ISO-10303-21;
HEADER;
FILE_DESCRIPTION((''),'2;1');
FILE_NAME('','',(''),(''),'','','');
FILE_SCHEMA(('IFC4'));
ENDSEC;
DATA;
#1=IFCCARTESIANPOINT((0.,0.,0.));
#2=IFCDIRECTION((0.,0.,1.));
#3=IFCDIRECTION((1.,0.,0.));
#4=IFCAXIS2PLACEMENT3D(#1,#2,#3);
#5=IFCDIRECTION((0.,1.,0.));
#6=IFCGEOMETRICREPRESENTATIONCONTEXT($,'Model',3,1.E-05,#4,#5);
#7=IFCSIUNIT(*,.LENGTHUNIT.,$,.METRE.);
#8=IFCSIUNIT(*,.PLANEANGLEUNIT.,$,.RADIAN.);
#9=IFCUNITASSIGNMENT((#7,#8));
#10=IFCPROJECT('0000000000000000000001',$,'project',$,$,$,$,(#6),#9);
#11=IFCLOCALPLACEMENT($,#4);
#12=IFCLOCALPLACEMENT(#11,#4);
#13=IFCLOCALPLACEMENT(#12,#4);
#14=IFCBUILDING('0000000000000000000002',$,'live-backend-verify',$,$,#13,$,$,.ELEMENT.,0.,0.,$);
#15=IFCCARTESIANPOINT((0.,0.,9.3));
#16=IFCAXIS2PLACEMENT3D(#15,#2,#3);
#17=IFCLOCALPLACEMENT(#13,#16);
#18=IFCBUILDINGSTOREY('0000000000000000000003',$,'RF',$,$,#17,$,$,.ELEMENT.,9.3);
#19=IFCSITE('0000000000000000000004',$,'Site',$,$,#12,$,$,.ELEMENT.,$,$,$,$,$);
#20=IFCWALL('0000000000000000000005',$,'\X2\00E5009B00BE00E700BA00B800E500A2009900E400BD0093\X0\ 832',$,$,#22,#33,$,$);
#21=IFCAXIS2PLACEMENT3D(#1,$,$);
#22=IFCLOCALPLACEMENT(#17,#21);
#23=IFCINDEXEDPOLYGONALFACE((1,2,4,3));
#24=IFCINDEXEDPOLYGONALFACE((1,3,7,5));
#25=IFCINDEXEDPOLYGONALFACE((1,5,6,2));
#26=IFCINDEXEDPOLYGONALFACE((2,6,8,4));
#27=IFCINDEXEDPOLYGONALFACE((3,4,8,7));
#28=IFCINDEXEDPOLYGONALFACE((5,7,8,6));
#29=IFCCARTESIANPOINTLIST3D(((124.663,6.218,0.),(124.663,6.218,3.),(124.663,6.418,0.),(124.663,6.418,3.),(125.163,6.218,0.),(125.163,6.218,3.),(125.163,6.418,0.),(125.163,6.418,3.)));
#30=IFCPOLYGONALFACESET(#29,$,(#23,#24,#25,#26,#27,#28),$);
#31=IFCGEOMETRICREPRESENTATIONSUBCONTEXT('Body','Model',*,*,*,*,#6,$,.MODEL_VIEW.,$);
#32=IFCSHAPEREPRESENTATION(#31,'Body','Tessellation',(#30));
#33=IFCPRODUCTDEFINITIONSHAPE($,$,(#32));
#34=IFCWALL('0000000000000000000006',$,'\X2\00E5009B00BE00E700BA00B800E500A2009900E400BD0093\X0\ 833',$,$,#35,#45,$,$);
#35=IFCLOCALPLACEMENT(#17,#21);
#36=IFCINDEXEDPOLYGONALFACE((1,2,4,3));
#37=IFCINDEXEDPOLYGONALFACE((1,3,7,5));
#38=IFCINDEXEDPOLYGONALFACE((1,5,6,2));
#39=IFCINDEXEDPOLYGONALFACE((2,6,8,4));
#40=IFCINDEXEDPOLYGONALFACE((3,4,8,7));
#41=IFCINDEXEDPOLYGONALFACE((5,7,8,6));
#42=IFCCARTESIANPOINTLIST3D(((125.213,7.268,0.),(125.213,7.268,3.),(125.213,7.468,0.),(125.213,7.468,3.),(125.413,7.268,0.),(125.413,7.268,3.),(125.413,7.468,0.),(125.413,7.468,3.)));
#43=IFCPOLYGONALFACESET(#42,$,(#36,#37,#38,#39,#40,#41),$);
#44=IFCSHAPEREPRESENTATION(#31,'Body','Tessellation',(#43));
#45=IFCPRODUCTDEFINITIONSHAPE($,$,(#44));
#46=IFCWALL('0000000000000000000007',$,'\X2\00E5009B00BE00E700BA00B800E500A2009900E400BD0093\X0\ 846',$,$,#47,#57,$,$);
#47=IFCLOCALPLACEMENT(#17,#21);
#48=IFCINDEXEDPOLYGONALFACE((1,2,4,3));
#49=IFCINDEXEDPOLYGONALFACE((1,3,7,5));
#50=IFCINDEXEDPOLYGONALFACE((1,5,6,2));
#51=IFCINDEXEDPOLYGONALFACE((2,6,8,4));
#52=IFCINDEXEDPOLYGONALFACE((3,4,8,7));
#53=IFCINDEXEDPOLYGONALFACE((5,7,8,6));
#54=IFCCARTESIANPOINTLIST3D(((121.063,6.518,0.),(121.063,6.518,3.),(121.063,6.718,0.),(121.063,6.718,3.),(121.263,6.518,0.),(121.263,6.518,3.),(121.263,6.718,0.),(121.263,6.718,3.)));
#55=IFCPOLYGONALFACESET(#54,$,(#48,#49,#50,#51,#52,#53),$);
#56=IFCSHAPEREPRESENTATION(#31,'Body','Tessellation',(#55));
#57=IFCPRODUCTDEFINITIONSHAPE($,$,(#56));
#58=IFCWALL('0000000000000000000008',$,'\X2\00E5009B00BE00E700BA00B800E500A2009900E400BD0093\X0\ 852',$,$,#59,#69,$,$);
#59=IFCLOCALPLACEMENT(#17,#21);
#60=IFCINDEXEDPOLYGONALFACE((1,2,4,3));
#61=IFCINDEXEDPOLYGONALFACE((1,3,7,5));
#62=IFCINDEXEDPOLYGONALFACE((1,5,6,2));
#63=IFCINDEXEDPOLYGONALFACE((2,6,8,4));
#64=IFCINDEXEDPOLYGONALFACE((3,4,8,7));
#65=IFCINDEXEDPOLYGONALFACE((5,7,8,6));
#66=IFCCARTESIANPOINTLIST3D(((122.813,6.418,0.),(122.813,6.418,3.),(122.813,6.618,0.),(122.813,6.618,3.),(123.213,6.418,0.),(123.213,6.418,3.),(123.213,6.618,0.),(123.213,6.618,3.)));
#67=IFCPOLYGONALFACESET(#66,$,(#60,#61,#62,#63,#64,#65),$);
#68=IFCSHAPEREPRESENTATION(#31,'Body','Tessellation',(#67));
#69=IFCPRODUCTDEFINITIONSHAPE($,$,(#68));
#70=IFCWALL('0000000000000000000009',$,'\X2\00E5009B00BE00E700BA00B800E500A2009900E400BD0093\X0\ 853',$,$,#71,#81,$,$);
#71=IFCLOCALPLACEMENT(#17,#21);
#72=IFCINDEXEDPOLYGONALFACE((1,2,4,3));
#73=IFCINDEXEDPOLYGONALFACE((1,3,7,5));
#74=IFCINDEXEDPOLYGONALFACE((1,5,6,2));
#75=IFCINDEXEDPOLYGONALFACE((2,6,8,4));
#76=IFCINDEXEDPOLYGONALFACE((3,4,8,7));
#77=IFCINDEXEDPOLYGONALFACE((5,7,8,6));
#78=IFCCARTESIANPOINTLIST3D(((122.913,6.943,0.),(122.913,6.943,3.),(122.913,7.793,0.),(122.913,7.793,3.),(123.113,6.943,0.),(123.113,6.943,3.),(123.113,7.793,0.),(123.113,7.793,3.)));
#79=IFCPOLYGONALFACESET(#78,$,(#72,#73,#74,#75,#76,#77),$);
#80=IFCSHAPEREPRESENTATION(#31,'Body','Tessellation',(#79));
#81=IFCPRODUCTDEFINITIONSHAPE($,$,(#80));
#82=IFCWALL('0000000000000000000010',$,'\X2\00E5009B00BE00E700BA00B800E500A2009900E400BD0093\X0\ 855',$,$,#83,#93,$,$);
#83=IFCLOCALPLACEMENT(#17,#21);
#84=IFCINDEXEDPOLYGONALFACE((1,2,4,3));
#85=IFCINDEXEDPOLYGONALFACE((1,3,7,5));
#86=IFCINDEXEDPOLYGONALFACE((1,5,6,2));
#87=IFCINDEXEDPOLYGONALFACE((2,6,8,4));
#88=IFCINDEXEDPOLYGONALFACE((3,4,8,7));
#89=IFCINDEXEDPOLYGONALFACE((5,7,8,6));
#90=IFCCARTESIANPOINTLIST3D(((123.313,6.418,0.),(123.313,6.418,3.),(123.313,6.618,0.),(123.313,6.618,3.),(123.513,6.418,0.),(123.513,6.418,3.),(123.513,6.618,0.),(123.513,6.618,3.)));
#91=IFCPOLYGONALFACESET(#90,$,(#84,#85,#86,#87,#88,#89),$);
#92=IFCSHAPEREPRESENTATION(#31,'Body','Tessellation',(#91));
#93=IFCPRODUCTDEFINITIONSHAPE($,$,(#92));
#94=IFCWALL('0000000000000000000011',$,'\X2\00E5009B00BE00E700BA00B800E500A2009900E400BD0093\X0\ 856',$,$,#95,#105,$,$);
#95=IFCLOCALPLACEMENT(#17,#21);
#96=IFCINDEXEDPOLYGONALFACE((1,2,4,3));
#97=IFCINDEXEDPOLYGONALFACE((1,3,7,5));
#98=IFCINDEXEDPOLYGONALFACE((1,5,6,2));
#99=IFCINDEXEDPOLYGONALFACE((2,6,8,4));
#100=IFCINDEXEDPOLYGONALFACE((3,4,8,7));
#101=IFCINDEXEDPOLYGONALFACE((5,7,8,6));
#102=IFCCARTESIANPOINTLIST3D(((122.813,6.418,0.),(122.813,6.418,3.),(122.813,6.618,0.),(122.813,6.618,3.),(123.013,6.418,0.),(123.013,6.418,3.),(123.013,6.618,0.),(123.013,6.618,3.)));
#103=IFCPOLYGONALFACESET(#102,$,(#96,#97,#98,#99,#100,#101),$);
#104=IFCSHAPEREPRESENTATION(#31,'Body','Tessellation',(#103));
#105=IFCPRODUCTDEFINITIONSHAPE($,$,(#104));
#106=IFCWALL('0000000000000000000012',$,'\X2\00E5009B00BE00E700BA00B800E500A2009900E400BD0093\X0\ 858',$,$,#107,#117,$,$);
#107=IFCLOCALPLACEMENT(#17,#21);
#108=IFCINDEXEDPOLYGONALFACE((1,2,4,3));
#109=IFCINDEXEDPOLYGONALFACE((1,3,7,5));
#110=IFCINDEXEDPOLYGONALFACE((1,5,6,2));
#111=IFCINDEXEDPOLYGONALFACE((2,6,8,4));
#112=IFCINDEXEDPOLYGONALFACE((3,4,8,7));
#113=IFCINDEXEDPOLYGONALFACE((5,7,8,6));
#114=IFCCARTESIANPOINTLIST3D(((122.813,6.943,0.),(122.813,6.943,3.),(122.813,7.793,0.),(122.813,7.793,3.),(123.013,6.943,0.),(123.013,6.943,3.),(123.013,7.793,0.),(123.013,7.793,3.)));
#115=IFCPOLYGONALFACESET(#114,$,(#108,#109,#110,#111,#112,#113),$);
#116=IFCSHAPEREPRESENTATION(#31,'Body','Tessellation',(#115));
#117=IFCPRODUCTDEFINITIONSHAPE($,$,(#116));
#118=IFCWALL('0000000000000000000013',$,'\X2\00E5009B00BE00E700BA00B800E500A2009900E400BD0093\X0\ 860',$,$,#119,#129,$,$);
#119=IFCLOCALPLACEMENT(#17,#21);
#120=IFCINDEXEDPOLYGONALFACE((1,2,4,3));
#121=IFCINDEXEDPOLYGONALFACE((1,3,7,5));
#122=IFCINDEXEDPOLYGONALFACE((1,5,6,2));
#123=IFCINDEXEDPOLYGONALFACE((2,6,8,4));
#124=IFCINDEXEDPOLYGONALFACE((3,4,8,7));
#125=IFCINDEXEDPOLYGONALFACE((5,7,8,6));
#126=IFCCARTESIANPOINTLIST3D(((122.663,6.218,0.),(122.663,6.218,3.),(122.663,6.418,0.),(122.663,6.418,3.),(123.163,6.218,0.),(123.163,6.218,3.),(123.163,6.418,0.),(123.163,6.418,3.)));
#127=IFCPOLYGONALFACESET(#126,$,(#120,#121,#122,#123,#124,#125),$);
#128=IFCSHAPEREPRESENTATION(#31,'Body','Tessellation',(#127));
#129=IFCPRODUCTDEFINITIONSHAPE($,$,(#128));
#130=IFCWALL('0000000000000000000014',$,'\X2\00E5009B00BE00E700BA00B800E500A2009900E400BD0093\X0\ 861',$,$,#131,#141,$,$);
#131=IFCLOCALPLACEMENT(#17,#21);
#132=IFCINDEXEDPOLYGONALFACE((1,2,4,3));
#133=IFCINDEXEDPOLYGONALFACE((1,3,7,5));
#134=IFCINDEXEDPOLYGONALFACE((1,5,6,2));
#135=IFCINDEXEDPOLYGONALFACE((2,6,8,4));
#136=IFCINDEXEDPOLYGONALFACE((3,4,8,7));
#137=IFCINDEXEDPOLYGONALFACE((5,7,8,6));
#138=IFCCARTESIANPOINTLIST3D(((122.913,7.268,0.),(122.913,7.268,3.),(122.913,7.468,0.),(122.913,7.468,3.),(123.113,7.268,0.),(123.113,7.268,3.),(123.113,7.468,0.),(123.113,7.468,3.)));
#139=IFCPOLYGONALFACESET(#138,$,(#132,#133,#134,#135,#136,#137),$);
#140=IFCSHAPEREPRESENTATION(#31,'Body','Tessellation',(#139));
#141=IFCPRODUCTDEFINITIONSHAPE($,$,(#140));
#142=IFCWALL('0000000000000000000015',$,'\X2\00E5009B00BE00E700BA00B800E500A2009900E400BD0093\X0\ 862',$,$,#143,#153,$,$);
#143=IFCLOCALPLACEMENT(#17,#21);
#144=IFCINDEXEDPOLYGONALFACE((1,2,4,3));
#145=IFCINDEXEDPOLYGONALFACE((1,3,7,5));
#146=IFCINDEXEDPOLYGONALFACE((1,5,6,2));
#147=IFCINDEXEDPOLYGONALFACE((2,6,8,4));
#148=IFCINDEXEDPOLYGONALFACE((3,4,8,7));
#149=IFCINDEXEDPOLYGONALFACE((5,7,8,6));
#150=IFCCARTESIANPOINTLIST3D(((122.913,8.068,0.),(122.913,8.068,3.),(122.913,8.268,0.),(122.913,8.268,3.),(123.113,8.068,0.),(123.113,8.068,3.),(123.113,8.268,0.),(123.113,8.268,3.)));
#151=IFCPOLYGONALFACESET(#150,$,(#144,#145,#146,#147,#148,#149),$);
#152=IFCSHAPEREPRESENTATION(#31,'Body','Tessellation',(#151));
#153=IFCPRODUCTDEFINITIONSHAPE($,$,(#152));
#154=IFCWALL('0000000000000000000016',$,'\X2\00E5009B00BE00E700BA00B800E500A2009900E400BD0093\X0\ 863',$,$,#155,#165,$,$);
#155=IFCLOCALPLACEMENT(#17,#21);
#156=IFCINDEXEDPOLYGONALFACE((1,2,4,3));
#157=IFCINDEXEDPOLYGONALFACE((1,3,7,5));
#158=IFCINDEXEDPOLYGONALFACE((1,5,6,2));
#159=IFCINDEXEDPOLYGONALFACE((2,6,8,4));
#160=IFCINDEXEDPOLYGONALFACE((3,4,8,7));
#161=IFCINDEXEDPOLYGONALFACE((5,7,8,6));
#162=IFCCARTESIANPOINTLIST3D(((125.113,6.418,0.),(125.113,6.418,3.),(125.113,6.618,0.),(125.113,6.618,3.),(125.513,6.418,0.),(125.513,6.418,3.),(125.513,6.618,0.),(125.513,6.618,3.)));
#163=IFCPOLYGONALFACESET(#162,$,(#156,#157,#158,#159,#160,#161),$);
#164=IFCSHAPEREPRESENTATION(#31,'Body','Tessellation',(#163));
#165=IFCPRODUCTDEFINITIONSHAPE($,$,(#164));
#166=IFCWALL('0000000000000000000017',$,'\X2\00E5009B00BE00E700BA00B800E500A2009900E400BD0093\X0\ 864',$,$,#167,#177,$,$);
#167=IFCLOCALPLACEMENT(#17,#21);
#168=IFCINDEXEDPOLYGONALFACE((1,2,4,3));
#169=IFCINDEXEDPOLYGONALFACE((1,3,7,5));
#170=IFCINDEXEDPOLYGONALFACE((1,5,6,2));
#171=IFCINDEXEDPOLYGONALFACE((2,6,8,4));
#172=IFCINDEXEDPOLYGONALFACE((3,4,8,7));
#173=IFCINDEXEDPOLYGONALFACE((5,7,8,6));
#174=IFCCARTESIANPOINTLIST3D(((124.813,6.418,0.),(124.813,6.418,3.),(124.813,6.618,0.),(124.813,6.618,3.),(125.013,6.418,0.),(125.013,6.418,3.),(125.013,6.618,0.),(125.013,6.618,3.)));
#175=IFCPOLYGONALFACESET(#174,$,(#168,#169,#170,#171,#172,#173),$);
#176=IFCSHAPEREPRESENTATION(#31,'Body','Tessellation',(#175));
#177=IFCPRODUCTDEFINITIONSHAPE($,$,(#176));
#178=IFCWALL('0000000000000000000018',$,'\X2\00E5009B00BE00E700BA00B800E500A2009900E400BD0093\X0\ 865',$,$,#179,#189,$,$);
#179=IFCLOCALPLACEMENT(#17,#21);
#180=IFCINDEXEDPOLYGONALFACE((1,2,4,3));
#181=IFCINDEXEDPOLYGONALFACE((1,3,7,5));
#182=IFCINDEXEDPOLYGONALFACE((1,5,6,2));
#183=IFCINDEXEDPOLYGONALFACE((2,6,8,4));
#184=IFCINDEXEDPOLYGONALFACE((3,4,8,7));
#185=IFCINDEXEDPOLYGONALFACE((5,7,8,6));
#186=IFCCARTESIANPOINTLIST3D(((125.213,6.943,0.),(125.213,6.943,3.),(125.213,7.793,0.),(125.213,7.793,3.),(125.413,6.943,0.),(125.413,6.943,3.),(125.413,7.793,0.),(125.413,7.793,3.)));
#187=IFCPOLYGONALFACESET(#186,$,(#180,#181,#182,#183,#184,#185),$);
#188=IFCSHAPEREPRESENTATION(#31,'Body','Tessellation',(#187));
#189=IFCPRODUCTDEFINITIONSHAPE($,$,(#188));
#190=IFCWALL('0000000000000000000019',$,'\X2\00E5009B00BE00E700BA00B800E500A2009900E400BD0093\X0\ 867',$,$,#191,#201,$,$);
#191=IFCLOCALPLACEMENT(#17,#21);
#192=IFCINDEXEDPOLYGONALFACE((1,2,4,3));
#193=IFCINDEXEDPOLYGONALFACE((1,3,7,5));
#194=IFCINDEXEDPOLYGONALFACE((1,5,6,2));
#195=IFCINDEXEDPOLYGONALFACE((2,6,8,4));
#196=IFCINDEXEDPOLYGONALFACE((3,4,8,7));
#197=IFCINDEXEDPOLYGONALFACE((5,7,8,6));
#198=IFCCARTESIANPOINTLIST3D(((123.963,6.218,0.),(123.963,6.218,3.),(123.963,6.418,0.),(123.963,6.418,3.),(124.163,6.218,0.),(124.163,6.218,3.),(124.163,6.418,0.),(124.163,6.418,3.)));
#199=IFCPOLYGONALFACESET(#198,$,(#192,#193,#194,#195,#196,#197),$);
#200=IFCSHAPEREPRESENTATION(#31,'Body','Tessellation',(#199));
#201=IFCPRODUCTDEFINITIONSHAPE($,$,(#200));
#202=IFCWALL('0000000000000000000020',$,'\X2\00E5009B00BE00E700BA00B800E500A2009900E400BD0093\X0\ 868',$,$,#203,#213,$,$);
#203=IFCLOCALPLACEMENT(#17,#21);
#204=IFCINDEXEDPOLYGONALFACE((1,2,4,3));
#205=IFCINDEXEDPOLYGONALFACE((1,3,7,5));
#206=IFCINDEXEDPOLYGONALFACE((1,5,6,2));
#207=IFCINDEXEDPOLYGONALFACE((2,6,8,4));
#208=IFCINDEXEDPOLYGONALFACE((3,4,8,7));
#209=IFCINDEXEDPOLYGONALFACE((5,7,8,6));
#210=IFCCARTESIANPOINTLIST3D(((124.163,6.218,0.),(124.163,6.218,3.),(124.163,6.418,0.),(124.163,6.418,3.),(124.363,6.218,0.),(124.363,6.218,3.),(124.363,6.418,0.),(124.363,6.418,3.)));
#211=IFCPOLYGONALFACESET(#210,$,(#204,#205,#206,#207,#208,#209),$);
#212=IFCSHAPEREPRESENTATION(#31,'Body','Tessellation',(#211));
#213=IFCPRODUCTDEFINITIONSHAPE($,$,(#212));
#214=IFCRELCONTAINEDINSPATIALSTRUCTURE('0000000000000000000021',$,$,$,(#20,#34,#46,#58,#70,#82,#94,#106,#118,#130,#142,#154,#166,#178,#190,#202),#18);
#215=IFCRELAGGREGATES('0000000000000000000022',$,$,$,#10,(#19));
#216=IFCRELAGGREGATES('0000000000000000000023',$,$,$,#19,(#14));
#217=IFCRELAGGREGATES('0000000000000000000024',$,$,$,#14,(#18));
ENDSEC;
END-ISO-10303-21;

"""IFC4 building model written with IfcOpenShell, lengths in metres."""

from ifc_helpers import new_model, si_unit, direction, frame, frame_2d, origin_with_axes, place, context, subcontext, project, spatial, rectangle, extrude, element, save


model = new_model("IFC4")

# Units and contexts
model_context = context("Model", 3, precision=1e-05, world=origin_with_axes(), true_north=direction((0.0, 1.0, 0.0)))
body_context = subcontext(model_context, "Body", "Model", "MODEL_VIEW")
ifc_project = project(units=[si_unit("LENGTHUNIT", "METRE"), si_unit("PLANEANGLEUNIT", "RADIAN")], contexts=[model_context])

# Site, building, storey
placement = place(None, origin_with_axes())
site_placement = place(placement, origin_with_axes())
site = spatial("IfcSite", under=ifc_project, at=site_placement, Name="Site", CompositionType="ELEMENT")
building_placement = place(site_placement, origin_with_axes())
building = spatial("IfcBuilding", under=site, at=building_placement, Name="live-backend-verify", CompositionType="ELEMENT", ElevationOfRefHeight=0.0, ElevationOfTerrain=0.0)
storey_placement = place(building_placement, frame((0.0, 0.0, 9.3), z_axis=(0.0, 0.0, 1.0), x_axis=(1.0, 0.0, 0.0)))
storey = spatial("IfcBuildingStorey", under=building, at=storey_placement, Name="RF", CompositionType="ELEMENT", Elevation=9.3)

# Walls
wall_1_placement = place(storey_placement, frame((124.913, 6.318, 0.0), z_axis=(0.0, 0.0, 1.0), x_axis=(1.0, 0.0, 0.0)))
element("IfcWall", 1, at=wall_1_placement, inside=storey, Name="å\u009b¾çº¸å¢\u0099ä½\u0093 832", context=body_context, shape_type="SweptSolid", body=[
    extrude(rectangle(XDim=0.5, YDim=0.2, at=frame_2d((0.0, 0.0), x_axis=(1.0, 0.0, 0.0))), frame((0.0, 0.0, 0.0), z_axis=(0.0, 0.0, 1.0)), (0.0, 0.0, 1.0), 3.0),
])
for number, where, z_axis, x_axis, name in (
    (2, (125.313, 7.368, 0.0), (0.0, 0.0, 1.0), (1.0, 0.0, 0.0), "å\u009b¾çº¸å¢\u0099ä½\u0093 833"),
    (3, (121.163, 6.618, 0.0), (0.0, 0.0, 1.0), (0.0, -1.0, 0.0), "å\u009b¾çº¸å¢\u0099ä½\u0093 846"),
):
    element("IfcWall", number, at=place(storey_placement, frame(where, z_axis=z_axis, x_axis=x_axis)), inside=storey, Name=name, context=body_context, shape_type="SweptSolid", body=[
        extrude(rectangle(XDim=0.2, YDim=0.2, at=frame_2d((0.0, 0.0), x_axis=(1.0, 0.0, 0.0))), frame((0.0, 0.0, 0.0), z_axis=(0.0, 0.0, 1.0)), (0.0, 0.0, 1.0), 3.0),
    ])
wall_2_placement = place(storey_placement, frame((123.013, 6.518, 0.0), z_axis=(0.0, 0.0, 1.0), x_axis=(1.0, 0.0, 0.0)))
element("IfcWall", 4, at=wall_2_placement, inside=storey, Name="å\u009b¾çº¸å¢\u0099ä½\u0093 852", context=body_context, shape_type="SweptSolid", body=[
    extrude(rectangle(XDim=0.4, YDim=0.2, at=frame_2d((0.0, 0.0), x_axis=(1.0, 0.0, 0.0))), frame((0.0, 0.0, 0.0), z_axis=(0.0, 0.0, 1.0)), (0.0, 0.0, 1.0), 3.0),
])
wall_3_placement = place(storey_placement, frame((123.013, 7.368, 0.0), z_axis=(0.0, 0.0, 1.0), x_axis=(0.0, -1.0, 0.0)))
element("IfcWall", 5, at=wall_3_placement, inside=storey, Name="å\u009b¾çº¸å¢\u0099ä½\u0093 853", context=body_context, shape_type="SweptSolid", body=[
    extrude(rectangle(XDim=0.85, YDim=0.2, at=frame_2d((0.0, 0.0), x_axis=(1.0, 0.0, 0.0))), frame((0.0, 0.0, 0.0), z_axis=(0.0, 0.0, 1.0)), (0.0, 0.0, 1.0), 3.0),
])
for number, where, z_axis, x_axis, name in (
    (6, (123.413, 6.518, 0.0), (0.0, 0.0, 1.0), (0.0, -1.0, 0.0), "å\u009b¾çº¸å¢\u0099ä½\u0093 855"),
    (7, (122.913, 6.518, 0.0), (0.0, 0.0, 1.0), (0.0, -1.0, 0.0), "å\u009b¾çº¸å¢\u0099ä½\u0093 856"),
):
    element("IfcWall", number, at=place(storey_placement, frame(where, z_axis=z_axis, x_axis=x_axis)), inside=storey, Name=name, context=body_context, shape_type="SweptSolid", body=[
        extrude(rectangle(XDim=0.2, YDim=0.2, at=frame_2d((0.0, 0.0), x_axis=(1.0, 0.0, 0.0))), frame((0.0, 0.0, 0.0), z_axis=(0.0, 0.0, 1.0)), (0.0, 0.0, 1.0), 3.0),
    ])
wall_4_placement = place(storey_placement, frame((122.913, 7.368, 0.0), z_axis=(0.0, 0.0, 1.0), x_axis=(0.0, -1.0, 0.0)))
element("IfcWall", 8, at=wall_4_placement, inside=storey, Name="å\u009b¾çº¸å¢\u0099ä½\u0093 858", context=body_context, shape_type="SweptSolid", body=[
    extrude(rectangle(XDim=0.85, YDim=0.2, at=frame_2d((0.0, 0.0), x_axis=(1.0, 0.0, 0.0))), frame((0.0, 0.0, 0.0), z_axis=(0.0, 0.0, 1.0)), (0.0, 0.0, 1.0), 3.0),
])
wall_5_placement = place(storey_placement, frame((122.913, 6.318, 0.0), z_axis=(0.0, 0.0, 1.0), x_axis=(1.0, 0.0, 0.0)))
element("IfcWall", 9, at=wall_5_placement, inside=storey, Name="å\u009b¾çº¸å¢\u0099ä½\u0093 860", context=body_context, shape_type="SweptSolid", body=[
    extrude(rectangle(XDim=0.5, YDim=0.2, at=frame_2d((0.0, 0.0), x_axis=(1.0, 0.0, 0.0))), frame((0.0, 0.0, 0.0), z_axis=(0.0, 0.0, 1.0)), (0.0, 0.0, 1.0), 3.0),
])
for number, where, z_axis, x_axis, name in (
    (10, (123.013, 7.368, 0.0), (0.0, 0.0, 1.0), (-1.0, 0.0, 0.0), "å\u009b¾çº¸å¢\u0099ä½\u0093 861"),
    (11, (123.013, 8.168, 0.0), (0.0, 0.0, 1.0), (-1.0, 0.0, 0.0), "å\u009b¾çº¸å¢\u0099ä½\u0093 862"),
):
    element("IfcWall", number, at=place(storey_placement, frame(where, z_axis=z_axis, x_axis=x_axis)), inside=storey, Name=name, context=body_context, shape_type="SweptSolid", body=[
        extrude(rectangle(XDim=0.2, YDim=0.2, at=frame_2d((0.0, 0.0), x_axis=(1.0, 0.0, 0.0))), frame((0.0, 0.0, 0.0), z_axis=(0.0, 0.0, 1.0)), (0.0, 0.0, 1.0), 3.0),
    ])
wall_6_placement = place(storey_placement, frame((125.313, 6.518, 0.0), z_axis=(0.0, 0.0, 1.0), x_axis=(-1.0, 0.0, 0.0)))
element("IfcWall", 12, at=wall_6_placement, inside=storey, Name="å\u009b¾çº¸å¢\u0099ä½\u0093 863", context=body_context, shape_type="SweptSolid", body=[
    extrude(rectangle(XDim=0.4, YDim=0.2, at=frame_2d((0.0, 0.0), x_axis=(1.0, 0.0, 0.0))), frame((0.0, 0.0, 0.0), z_axis=(0.0, 0.0, 1.0)), (0.0, 0.0, 1.0), 3.0),
])
wall_7_placement = place(storey_placement, frame((124.913, 6.518, 0.0), z_axis=(0.0, 0.0, 1.0), x_axis=(0.0, -1.0, 0.0)))
element("IfcWall", 13, at=wall_7_placement, inside=storey, Name="å\u009b¾çº¸å¢\u0099ä½\u0093 864", context=body_context, shape_type="SweptSolid", body=[
    extrude(rectangle(XDim=0.2, YDim=0.2, at=frame_2d((0.0, 0.0), x_axis=(1.0, 0.0, 0.0))), frame((0.0, 0.0, 0.0), z_axis=(0.0, 0.0, 1.0)), (0.0, 0.0, 1.0), 3.0),
])
wall_8_placement = place(storey_placement, frame((125.313, 7.368, 0.0), z_axis=(0.0, 0.0, 1.0), x_axis=(0.0, -1.0, 0.0)))
element("IfcWall", 14, at=wall_8_placement, inside=storey, Name="å\u009b¾çº¸å¢\u0099ä½\u0093 865", context=body_context, shape_type="SweptSolid", body=[
    extrude(rectangle(XDim=0.85, YDim=0.2, at=frame_2d((0.0, 0.0), x_axis=(1.0, 0.0, 0.0))), frame((0.0, 0.0, 0.0), z_axis=(0.0, 0.0, 1.0)), (0.0, 0.0, 1.0), 3.0),
])
for number, where, z_axis, x_axis, name in (
    (15, (124.063, 6.318, 0.0), (0.0, 0.0, 1.0), (1.0, 0.0, 0.0), "å\u009b¾çº¸å¢\u0099ä½\u0093 867"),
    (16, (124.263, 6.318, 0.0), (0.0, 0.0, 1.0), (1.0, 0.0, 0.0), "å\u009b¾çº¸å¢\u0099ä½\u0093 868"),
):
    element("IfcWall", number, at=place(storey_placement, frame(where, z_axis=z_axis, x_axis=x_axis)), inside=storey, Name=name, context=body_context, shape_type="SweptSolid", body=[
        extrude(rectangle(XDim=0.2, YDim=0.2, at=frame_2d((0.0, 0.0), x_axis=(1.0, 0.0, 0.0))), frame((0.0, 0.0, 0.0), z_axis=(0.0, 0.0, 1.0)), (0.0, 0.0, 1.0), 3.0),
    ])

save(model, "model.ifc")
